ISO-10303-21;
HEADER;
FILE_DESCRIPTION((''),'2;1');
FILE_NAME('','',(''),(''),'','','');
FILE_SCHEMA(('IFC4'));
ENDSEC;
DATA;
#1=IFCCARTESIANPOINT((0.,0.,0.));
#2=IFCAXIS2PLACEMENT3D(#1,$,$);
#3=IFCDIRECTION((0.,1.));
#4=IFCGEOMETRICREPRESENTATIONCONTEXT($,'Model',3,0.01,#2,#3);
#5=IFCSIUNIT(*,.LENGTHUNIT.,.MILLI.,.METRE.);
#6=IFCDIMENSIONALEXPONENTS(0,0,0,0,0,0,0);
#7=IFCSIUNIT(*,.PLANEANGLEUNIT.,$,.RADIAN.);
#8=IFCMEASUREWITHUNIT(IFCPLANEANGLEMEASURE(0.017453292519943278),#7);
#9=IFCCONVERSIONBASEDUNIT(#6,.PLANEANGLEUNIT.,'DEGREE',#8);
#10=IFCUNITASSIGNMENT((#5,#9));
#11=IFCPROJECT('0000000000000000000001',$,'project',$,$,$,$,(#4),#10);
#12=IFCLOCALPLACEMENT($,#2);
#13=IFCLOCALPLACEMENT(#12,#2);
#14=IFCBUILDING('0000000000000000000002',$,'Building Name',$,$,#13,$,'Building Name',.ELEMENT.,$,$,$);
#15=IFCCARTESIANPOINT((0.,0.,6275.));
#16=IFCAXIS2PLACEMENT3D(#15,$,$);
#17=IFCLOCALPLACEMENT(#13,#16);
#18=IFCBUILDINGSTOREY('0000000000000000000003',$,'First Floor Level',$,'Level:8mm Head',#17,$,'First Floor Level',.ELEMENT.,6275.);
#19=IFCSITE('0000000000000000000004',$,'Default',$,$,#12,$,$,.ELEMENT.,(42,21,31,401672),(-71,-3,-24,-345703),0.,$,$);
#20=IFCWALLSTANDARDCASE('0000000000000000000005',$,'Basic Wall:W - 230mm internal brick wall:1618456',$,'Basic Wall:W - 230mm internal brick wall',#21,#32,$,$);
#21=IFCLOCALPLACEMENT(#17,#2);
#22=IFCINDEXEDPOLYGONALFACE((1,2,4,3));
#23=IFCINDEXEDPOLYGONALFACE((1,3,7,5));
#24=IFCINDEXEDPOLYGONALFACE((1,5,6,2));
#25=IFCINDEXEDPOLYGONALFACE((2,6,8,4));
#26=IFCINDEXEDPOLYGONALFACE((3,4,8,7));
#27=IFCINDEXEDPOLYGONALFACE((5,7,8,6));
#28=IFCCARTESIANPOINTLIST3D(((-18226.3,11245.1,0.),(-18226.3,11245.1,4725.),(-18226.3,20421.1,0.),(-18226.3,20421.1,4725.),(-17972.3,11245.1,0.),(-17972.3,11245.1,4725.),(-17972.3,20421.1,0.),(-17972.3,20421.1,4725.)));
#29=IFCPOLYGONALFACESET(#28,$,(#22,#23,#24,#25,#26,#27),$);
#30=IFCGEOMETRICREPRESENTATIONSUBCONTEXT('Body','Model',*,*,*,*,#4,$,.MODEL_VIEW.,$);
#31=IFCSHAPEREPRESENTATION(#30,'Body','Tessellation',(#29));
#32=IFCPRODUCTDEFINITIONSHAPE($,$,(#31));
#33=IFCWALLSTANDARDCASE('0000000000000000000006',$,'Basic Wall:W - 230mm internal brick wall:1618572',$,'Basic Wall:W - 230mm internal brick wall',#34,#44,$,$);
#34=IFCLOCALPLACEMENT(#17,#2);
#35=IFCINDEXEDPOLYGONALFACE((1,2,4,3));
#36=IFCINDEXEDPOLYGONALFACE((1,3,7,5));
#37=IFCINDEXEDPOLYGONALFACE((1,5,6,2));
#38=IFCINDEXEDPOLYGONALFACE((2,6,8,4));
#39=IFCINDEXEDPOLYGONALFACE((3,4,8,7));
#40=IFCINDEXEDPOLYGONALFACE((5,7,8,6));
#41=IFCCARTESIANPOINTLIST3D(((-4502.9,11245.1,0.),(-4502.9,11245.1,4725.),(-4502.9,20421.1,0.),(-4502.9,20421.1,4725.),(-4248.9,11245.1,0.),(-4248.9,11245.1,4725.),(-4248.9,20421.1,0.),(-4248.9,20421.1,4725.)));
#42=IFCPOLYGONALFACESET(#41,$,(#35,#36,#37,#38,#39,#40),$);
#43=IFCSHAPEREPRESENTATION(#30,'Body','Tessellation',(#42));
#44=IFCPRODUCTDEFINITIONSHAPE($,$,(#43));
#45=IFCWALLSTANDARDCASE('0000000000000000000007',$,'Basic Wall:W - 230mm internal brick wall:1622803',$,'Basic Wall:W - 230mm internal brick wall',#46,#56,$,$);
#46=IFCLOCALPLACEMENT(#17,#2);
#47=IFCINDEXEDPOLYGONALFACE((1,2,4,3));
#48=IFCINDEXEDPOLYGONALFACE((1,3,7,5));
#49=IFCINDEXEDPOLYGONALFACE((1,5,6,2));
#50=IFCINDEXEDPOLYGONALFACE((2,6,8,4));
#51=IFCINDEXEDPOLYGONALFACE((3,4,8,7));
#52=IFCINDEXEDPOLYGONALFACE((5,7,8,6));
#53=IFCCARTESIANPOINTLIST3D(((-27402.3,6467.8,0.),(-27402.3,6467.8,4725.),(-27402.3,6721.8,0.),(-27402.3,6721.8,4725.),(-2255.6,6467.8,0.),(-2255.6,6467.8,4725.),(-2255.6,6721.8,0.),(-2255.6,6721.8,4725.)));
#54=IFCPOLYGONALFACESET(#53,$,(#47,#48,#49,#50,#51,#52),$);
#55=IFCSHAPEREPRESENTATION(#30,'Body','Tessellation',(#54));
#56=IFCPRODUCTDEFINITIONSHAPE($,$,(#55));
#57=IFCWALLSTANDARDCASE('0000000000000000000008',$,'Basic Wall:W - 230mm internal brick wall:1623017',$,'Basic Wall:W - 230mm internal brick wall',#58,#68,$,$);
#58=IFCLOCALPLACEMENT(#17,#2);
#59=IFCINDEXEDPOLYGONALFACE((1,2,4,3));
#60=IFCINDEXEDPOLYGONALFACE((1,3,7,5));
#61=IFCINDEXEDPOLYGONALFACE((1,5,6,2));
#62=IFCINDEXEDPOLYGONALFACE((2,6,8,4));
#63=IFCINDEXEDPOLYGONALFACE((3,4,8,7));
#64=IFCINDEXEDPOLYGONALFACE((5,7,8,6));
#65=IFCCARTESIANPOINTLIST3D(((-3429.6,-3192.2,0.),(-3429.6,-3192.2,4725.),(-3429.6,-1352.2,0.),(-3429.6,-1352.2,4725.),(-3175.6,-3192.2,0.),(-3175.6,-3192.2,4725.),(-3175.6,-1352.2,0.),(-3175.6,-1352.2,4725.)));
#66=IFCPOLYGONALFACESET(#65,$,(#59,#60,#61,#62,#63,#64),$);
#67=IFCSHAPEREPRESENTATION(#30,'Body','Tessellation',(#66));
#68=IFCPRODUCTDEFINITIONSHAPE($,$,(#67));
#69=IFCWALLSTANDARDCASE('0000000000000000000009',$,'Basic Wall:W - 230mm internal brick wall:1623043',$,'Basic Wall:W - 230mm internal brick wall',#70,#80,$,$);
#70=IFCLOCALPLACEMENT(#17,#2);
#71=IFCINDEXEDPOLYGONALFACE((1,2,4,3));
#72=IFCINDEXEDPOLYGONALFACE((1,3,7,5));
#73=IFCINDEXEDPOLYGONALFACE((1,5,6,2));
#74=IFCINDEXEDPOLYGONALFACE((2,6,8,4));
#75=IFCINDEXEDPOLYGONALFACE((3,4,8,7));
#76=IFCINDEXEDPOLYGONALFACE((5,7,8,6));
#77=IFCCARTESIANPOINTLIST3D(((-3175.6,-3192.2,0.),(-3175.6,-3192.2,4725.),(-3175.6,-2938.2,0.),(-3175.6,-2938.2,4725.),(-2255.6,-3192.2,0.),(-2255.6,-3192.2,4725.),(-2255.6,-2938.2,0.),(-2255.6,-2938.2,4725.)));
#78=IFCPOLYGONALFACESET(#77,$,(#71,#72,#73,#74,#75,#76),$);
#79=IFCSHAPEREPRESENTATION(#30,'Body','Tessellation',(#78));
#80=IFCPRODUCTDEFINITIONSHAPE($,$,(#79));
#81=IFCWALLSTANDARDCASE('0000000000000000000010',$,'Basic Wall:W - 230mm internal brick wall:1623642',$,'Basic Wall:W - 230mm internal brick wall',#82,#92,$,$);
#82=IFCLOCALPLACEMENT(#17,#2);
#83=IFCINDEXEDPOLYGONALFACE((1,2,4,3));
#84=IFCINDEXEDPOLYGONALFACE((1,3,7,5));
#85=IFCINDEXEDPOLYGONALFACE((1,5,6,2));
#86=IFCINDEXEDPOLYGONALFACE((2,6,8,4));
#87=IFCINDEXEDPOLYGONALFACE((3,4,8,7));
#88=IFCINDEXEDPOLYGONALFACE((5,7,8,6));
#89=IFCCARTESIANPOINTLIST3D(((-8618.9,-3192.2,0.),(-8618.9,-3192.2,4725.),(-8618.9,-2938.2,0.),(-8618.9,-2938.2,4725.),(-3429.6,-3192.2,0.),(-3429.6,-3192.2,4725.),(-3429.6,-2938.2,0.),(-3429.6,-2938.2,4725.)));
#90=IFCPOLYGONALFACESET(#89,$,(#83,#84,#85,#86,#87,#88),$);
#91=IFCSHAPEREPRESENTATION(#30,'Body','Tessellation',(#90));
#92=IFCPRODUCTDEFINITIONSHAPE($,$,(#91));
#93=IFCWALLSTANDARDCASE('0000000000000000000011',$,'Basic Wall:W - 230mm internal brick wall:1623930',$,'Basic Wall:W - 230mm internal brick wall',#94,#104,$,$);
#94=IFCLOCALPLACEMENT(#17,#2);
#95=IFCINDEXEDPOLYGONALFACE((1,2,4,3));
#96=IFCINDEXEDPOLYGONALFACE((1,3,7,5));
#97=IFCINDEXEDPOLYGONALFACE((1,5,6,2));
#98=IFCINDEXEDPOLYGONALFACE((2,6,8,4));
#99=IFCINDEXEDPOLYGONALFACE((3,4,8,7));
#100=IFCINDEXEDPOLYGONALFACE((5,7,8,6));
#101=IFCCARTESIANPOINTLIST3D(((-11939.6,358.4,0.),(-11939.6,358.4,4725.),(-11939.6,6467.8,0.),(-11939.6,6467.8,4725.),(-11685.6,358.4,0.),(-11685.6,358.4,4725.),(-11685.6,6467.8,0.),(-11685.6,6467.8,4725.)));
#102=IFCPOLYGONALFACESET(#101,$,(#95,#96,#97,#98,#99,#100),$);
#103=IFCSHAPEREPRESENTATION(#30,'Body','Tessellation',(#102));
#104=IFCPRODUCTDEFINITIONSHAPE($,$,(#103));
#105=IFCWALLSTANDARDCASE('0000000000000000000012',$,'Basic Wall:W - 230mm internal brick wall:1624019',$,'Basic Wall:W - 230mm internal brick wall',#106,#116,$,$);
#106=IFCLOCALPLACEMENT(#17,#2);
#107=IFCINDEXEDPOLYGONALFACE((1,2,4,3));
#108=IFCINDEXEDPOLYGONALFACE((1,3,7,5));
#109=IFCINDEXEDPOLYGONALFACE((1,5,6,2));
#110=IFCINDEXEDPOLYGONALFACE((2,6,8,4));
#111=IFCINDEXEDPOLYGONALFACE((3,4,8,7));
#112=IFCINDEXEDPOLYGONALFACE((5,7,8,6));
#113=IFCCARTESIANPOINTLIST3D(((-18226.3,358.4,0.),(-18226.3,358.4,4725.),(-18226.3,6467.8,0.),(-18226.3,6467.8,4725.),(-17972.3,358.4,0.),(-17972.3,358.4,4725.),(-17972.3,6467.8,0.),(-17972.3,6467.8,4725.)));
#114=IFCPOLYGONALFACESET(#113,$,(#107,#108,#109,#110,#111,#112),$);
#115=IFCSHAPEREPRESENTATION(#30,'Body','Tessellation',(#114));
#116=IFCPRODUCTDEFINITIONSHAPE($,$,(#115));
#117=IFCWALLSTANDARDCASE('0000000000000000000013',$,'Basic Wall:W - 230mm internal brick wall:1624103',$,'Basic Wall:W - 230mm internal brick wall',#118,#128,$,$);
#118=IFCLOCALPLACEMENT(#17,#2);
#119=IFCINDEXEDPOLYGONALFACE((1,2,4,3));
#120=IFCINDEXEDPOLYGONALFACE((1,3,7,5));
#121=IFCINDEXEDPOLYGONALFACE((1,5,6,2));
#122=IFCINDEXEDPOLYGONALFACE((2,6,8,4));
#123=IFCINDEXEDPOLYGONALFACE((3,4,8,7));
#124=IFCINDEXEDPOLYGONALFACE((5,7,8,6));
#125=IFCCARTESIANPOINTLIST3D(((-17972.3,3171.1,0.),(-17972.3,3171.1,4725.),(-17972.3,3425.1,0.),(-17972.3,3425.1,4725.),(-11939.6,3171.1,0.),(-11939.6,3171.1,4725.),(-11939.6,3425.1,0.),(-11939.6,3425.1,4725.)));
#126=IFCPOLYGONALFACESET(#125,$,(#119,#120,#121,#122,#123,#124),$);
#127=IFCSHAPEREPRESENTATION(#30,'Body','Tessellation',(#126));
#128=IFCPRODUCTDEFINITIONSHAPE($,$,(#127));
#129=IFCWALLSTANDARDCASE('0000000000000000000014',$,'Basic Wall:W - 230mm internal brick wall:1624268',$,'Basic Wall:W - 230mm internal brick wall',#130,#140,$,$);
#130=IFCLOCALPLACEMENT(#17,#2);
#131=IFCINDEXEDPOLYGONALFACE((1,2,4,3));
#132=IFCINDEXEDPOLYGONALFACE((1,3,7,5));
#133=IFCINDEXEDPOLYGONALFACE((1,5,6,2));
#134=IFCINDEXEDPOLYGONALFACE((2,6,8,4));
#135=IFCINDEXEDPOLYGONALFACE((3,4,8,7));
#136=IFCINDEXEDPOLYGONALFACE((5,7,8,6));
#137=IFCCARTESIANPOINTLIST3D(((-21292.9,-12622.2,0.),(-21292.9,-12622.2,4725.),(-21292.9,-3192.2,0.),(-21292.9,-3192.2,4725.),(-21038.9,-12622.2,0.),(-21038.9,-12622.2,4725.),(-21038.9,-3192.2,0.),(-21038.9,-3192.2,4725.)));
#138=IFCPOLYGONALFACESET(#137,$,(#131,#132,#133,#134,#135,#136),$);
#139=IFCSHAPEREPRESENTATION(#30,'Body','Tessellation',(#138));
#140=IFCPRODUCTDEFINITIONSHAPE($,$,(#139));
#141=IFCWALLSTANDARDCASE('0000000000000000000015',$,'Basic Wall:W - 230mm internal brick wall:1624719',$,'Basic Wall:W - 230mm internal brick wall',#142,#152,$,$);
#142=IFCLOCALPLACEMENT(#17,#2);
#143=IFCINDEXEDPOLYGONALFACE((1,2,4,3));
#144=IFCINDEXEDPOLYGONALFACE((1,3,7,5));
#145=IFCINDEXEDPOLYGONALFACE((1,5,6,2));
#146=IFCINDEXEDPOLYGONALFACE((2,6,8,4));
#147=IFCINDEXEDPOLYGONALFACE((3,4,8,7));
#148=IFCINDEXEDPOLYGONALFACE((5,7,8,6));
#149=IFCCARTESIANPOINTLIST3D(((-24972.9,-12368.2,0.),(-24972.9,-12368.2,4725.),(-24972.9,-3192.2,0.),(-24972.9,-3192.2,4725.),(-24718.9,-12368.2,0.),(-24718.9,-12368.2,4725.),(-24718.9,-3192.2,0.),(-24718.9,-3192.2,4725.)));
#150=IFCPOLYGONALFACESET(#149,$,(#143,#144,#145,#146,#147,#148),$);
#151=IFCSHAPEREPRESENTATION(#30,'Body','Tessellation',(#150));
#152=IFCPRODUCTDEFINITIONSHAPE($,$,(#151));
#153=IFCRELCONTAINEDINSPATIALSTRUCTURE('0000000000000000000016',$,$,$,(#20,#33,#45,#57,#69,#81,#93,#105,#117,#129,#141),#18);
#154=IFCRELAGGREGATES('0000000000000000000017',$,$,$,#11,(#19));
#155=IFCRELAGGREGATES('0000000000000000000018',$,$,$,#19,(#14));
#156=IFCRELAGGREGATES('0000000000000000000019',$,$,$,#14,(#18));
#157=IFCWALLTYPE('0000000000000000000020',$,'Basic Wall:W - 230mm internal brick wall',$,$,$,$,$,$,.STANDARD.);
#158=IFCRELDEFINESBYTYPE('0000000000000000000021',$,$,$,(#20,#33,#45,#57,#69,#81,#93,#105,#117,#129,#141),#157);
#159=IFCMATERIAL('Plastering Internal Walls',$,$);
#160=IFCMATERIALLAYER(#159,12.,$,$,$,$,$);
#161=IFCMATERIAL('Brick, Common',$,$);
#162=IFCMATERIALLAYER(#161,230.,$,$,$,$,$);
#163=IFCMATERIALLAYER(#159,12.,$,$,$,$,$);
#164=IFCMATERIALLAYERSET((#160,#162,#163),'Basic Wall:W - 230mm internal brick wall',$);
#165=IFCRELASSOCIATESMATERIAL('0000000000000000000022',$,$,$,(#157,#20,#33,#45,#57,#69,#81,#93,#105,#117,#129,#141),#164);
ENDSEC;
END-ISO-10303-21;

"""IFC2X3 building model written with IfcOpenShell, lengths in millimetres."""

from ifc_helpers import new_model, entity, si_unit, converted_unit, direction, frame, frame_2d, origin, place, context, subcontext, project, spatial, rectangle, extrude, material, layer, layer_set, layer_usage, type_object, element, save


model = new_model("IFC2X3")

# Units and contexts
model_context = context("Model", 3, precision=0.01, world=origin(), true_north=direction((0.0, 1.0)))
body_context = subcontext(model_context, "Body", "Model", "MODEL_VIEW")
ifc_project = project(units=[si_unit("LENGTHUNIT", "METRE", prefix="MILLI"), converted_unit("PLANEANGLEUNIT", "DEGREE", entity("IfcPlaneAngleMeasure", 0.017453292519943278), si_unit("PLANEANGLEUNIT", "RADIAN"), dimensions=[0, 0, 0, 0, 0, 0, 0])], contexts=[model_context])

# Site, building, storey
site_placement = place(None, origin())
site = spatial("IfcSite", under=ifc_project, at=site_placement, Name="Default", CompositionType="ELEMENT", RefLatitude=(42, 21, 31, 401672), RefLongitude=(-71, -3, -24, -345703), RefElevation=0.0)
building_placement = place(site_placement, origin())
building = spatial("IfcBuilding", under=site, at=building_placement, Name="Building Name", LongName="Building Name", CompositionType="ELEMENT")
storey_placement = place(building_placement, frame((0.0, 0.0, 6275.0)))
storey = spatial("IfcBuildingStorey", under=building, at=storey_placement, Name="First Floor Level", ObjectType="Level:8mm Head", LongName="First Floor Level", CompositionType="ELEMENT", Elevation=6275.0)

# Walls
ifc_material_1 = material(Name="Brick, Common")
ifc_material_2 = material(Name="Plastering Internal Walls")
ifc_layer_1 = layer(ifc_material_2, 12.0)
ifc_layer_2 = layer(ifc_material_1, 230.0)
ifc_layer_3 = layer(ifc_material_2, 12.0)
ifc_layer_set_1 = layer_set([ifc_layer_1, ifc_layer_2, ifc_layer_3], Name="Basic Wall:W - 230mm internal brick wall")
ifc_layer_usage_1 = layer_usage(ifc_layer_set_1, "AXIS2", "NEGATIVE", 127.0)
wall_type_1 = type_object("IfcWallType", Name="Basic Wall:W - 230mm internal brick wall", PredefinedType="STANDARD", material=ifc_layer_set_1)
wall_1_placement = place(storey_placement, frame((-18099.3, 11245.1, 0.0), z_axis=(0.0, 0.0, 1.0), x_axis=(0.0, 1.0, 0.0)))
element("IfcWallStandardCase", 1, at=wall_1_placement, inside=storey, type_object=wall_type_1, material=ifc_layer_usage_1, Name="Basic Wall:W - 230mm internal brick wall:1618456", ObjectType="Basic Wall:W - 230mm internal brick wall", context=body_context, shape_type="SweptSolid", body=[
    extrude(rectangle(XDim=9176.0, YDim=254.0, at=frame_2d((4588.0, 0.0), x_axis=(-1.0, 0.0))), origin(), (0.0, 0.0, 1.0), 4725.0),
])
ifc_layer_usage_2 = layer_usage(ifc_layer_set_1, "AXIS2", "NEGATIVE", 127.0)
wall_2_placement = place(storey_placement, frame((-4375.9, 11245.1, 0.0), z_axis=(0.0, 0.0, 1.0), x_axis=(0.0, 1.0, 0.0)))
element("IfcWallStandardCase", 2, at=wall_2_placement, inside=storey, type_object=wall_type_1, material=ifc_layer_usage_2, Name="Basic Wall:W - 230mm internal brick wall:1618572", ObjectType="Basic Wall:W - 230mm internal brick wall", context=body_context, shape_type="SweptSolid", body=[
    extrude(rectangle(XDim=9176.0, YDim=254.0, at=frame_2d((4588.0, 0.0), x_axis=(-1.0, 0.0))), origin(), (0.0, 0.0, 1.0), 4725.0),
])
ifc_layer_usage_3 = layer_usage(ifc_layer_set_1, "AXIS2", "NEGATIVE", 127.0)
wall_3_placement = place(storey_placement, frame((-27402.3, 6594.8, 0.0)))
element("IfcWallStandardCase", 3, at=wall_3_placement, inside=storey, type_object=wall_type_1, material=ifc_layer_usage_3, Name="Basic Wall:W - 230mm internal brick wall:1622803", ObjectType="Basic Wall:W - 230mm internal brick wall", context=body_context, shape_type="SweptSolid", body=[
    extrude(rectangle(XDim=25146.7, YDim=254.0, at=frame_2d((12573.3, 0.0), x_axis=(-1.0, 0.0))), origin(), (0.0, 0.0, 1.0), 4725.0),
])
ifc_layer_usage_4 = layer_usage(ifc_layer_set_1, "AXIS2", "NEGATIVE", 127.0)
wall_4_placement = place(storey_placement, frame((-3302.6, -1352.2, 0.0), z_axis=(0.0, 0.0, 1.0), x_axis=(0.0, -1.0, 0.0)))
element("IfcWallStandardCase", 4, at=wall_4_placement, inside=storey, type_object=wall_type_1, material=ifc_layer_usage_4, Name="Basic Wall:W - 230mm internal brick wall:1623017", ObjectType="Basic Wall:W - 230mm internal brick wall", context=body_context, shape_type="SweptSolid", body=[
    extrude(rectangle(XDim=1840.0, YDim=254.0, at=frame_2d((920.0, 0.0), x_axis=(-1.0, 0.0))), origin(), (0.0, 0.0, 1.0), 4725.0),
])
ifc_layer_usage_5 = layer_usage(ifc_layer_set_1, "AXIS2", "NEGATIVE", 127.0)
wall_5_placement = place(storey_placement, frame((-3175.6, -3065.2, 0.0)))
element("IfcWallStandardCase", 5, at=wall_5_placement, inside=storey, type_object=wall_type_1, material=ifc_layer_usage_5, Name="Basic Wall:W - 230mm internal brick wall:1623043", ObjectType="Basic Wall:W - 230mm internal brick wall", context=body_context, shape_type="SweptSolid", body=[
    extrude(rectangle(XDim=920.0, YDim=254.0, at=frame_2d((460.0, 0.0), x_axis=(-1.0, 0.0))), origin(), (0.0, 0.0, 1.0), 4725.0),
])
ifc_layer_usage_6 = layer_usage(ifc_layer_set_1, "AXIS2", "NEGATIVE", 127.0)
wall_6_placement = place(storey_placement, frame((-3429.6, -3065.2, 0.0), z_axis=(0.0, 0.0, 1.0), x_axis=(-1.0, 0.0, 0.0)))
element("IfcWallStandardCase", 6, at=wall_6_placement, inside=storey, type_object=wall_type_1, material=ifc_layer_usage_6, Name="Basic Wall:W - 230mm internal brick wall:1623642", ObjectType="Basic Wall:W - 230mm internal brick wall", context=body_context, shape_type="SweptSolid", body=[
    extrude(rectangle(XDim=5189.3, YDim=254.0, at=frame_2d((2594.7, 0.0), x_axis=(-1.0, 0.0))), origin(), (0.0, 0.0, 1.0), 4725.0),
])
ifc_layer_usage_7 = layer_usage(ifc_layer_set_1, "AXIS2", "NEGATIVE", 127.0)
wall_7_placement = place(storey_placement, frame((-11812.6, 358.4, 0.0), z_axis=(0.0, 0.0, 1.0), x_axis=(0.0, 1.0, 0.0)))
element("IfcWallStandardCase", 7, at=wall_7_placement, inside=storey, type_object=wall_type_1, material=ifc_layer_usage_7, Name="Basic Wall:W - 230mm internal brick wall:1623930", ObjectType="Basic Wall:W - 230mm internal brick wall", context=body_context, shape_type="SweptSolid", body=[
    extrude(rectangle(XDim=6109.3, YDim=254.0, at=frame_2d((3054.7, 0.0), x_axis=(-1.0, 0.0))), origin(), (0.0, 0.0, 1.0), 4725.0),
])
ifc_layer_usage_8 = layer_usage(ifc_layer_set_1, "AXIS2", "NEGATIVE", 127.0)
wall_8_placement = place(storey_placement, frame((-18099.3, 358.4, 0.0), z_axis=(0.0, 0.0, 1.0), x_axis=(0.0, 1.0, 0.0)))
element("IfcWallStandardCase", 8, at=wall_8_placement, inside=storey, type_object=wall_type_1, material=ifc_layer_usage_8, Name="Basic Wall:W - 230mm internal brick wall:1624019", ObjectType="Basic Wall:W - 230mm internal brick wall", context=body_context, shape_type="SweptSolid", body=[
    extrude(rectangle(XDim=6109.3, YDim=254.0, at=frame_2d((3054.7, 0.0), x_axis=(-1.0, 0.0))), origin(), (0.0, 0.0, 1.0), 4725.0),
])
ifc_layer_usage_9 = layer_usage(ifc_layer_set_1, "AXIS2", "NEGATIVE", 127.0)
wall_9_placement = place(storey_placement, frame((-11939.6, 3298.1, 0.0), z_axis=(0.0, 0.0, 1.0), x_axis=(-1.0, 0.0, 0.0)))
element("IfcWallStandardCase", 9, at=wall_9_placement, inside=storey, type_object=wall_type_1, material=ifc_layer_usage_9, Name="Basic Wall:W - 230mm internal brick wall:1624103", ObjectType="Basic Wall:W - 230mm internal brick wall", context=body_context, shape_type="SweptSolid", body=[
    extrude(rectangle(XDim=6032.7, YDim=254.0, at=frame_2d((3016.3, 0.0), x_axis=(-1.0, 0.0))), origin(), (0.0, 0.0, 1.0), 4725.0),
])
ifc_layer_usage_10 = layer_usage(ifc_layer_set_1, "AXIS2", "NEGATIVE", 127.0)
wall_10_placement = place(storey_placement, frame((-21165.9, -3192.2, 0.0), z_axis=(0.0, 0.0, 1.0), x_axis=(0.0, -1.0, 0.0)))
element("IfcWallStandardCase", 10, at=wall_10_placement, inside=storey, type_object=wall_type_1, material=ifc_layer_usage_10, Name="Basic Wall:W - 230mm internal brick wall:1624268", ObjectType="Basic Wall:W - 230mm internal brick wall", context=body_context, shape_type="SweptSolid", body=[
    extrude(rectangle(XDim=9430.0, YDim=254.0, at=frame_2d((4715.0, 0.0), x_axis=(-1.0, 0.0))), origin(), (0.0, 0.0, 1.0), 4725.0),
])
ifc_layer_usage_11 = layer_usage(ifc_layer_set_1, "AXIS2", "NEGATIVE", 127.0)
wall_11_placement = place(storey_placement, frame((-24845.9, -3192.2, 0.0), z_axis=(0.0, 0.0, 1.0), x_axis=(0.0, -1.0, 0.0)))
element("IfcWallStandardCase", 11, at=wall_11_placement, inside=storey, type_object=wall_type_1, material=ifc_layer_usage_11, Name="Basic Wall:W - 230mm internal brick wall:1624719", ObjectType="Basic Wall:W - 230mm internal brick wall", context=body_context, shape_type="SweptSolid", body=[
    extrude(rectangle(XDim=9176.0, YDim=254.0, at=frame_2d((4588.0, 0.0), x_axis=(-1.0, 0.0))), origin(), (0.0, 0.0, 1.0), 4725.0),
])

save(model, "model.ifc")
